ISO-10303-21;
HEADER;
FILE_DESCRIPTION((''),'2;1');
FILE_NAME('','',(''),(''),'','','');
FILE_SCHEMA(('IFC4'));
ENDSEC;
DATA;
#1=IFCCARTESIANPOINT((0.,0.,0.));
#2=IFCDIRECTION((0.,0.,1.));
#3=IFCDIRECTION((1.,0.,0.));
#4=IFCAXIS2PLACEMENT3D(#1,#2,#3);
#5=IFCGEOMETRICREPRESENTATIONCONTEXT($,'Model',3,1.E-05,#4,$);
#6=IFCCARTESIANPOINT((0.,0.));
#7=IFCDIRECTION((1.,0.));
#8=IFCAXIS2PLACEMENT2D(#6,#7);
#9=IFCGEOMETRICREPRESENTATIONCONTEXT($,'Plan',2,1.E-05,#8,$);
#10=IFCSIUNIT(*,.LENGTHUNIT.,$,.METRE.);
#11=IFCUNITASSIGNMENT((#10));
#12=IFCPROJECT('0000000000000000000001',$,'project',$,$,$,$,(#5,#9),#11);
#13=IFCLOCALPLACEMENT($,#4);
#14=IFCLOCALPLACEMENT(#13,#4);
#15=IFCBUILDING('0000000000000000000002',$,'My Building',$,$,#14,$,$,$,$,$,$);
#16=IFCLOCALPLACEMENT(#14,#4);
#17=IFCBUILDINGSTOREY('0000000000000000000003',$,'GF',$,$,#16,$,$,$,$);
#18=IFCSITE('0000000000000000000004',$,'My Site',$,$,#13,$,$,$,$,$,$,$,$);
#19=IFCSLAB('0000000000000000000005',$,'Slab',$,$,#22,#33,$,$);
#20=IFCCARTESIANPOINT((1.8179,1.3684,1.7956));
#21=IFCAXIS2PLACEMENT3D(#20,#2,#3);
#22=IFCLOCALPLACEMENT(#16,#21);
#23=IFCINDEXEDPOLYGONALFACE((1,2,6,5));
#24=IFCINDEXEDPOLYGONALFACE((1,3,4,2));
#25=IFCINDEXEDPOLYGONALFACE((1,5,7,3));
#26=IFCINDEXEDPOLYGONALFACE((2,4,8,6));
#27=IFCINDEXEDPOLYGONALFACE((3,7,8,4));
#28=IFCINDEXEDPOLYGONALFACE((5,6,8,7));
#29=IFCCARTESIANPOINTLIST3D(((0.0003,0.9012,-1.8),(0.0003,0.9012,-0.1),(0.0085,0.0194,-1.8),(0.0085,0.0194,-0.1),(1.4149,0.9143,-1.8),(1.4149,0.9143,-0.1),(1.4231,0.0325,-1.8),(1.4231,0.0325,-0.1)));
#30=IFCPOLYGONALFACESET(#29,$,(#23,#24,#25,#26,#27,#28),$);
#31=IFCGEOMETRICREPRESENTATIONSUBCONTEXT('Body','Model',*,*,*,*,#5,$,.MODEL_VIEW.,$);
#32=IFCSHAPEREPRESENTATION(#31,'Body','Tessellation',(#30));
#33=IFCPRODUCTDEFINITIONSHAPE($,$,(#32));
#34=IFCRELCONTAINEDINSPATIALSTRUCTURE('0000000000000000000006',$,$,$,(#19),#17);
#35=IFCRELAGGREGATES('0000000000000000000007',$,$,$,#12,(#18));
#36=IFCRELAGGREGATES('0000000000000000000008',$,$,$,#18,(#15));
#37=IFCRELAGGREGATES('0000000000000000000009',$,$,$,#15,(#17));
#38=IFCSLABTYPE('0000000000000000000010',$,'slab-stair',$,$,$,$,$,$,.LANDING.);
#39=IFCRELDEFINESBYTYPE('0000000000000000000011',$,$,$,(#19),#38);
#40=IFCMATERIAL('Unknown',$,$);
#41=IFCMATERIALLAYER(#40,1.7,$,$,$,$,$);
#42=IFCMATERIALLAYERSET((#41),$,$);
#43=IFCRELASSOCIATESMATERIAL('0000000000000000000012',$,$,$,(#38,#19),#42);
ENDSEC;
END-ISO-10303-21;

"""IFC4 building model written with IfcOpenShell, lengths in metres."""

from ifc_helpers import new_model, si_unit, frame, origin_with_axes, origin_2d_with_axis, place, context, subcontext, project, spatial, indexed_curve, outline, extrude, material, layer, layer_set, layer_usage, type_object, element, save


model = new_model("IFC4")

# Units and contexts
model_context = context("Model", 3, precision=1e-05, world=origin_with_axes())
plan_context = context("Plan", 2, precision=1e-05, world=origin_2d_with_axis())
body_context_1 = subcontext(model_context, "Body", "Model", "MODEL_VIEW")
ifc_project = project(units=[si_unit("LENGTHUNIT", "METRE")], contexts=[model_context, plan_context])

# Site, building, storey
site_placement = place(None, origin_with_axes())
site = spatial("IfcSite", under=ifc_project, at=site_placement, Name="My Site")
building_placement = place(site_placement, origin_with_axes())
building = spatial("IfcBuilding", under=site, at=building_placement, Name="My Building")
storey_placement = place(building_placement, origin_with_axes())
storey = spatial("IfcBuildingStorey", under=building, at=storey_placement, Name="GF")

# Shared definitions
ifc_material = material(Name="Unknown")

# Slab
ifc_layer_1 = layer(ifc_material, 1.7)
ifc_layer_set_1 = layer_set([ifc_layer_1])
ifc_layer_usage_1 = layer_usage(ifc_layer_set_1, "AXIS3", "POSITIVE", -1.8)
slab_type_1 = type_object("IfcSlabType", Name="slab-stair", PredefinedType="LANDING", material=ifc_layer_set_1)
slab_1_placement = place(storey_placement, frame((1.8179, 1.3684, 1.7956), z_axis=(0.0, 0.0, 1.0), x_axis=(1.0, 0.0, 0.0)))
element("IfcSlab", 1, at=slab_1_placement, inside=storey, type_object=slab_type_1, material=ifc_layer_usage_1, Name="Slab", context=body_context_1, shape_type="SweptSolid", body=[
    extrude(outline(indexed_curve([(0.0085, 0.0194), (0.0003, 0.9012), (1.4149, 0.9143), (1.4231, 0.0325), (0.0085, 0.0194)])), frame((0.0, 0.0, -1.8), z_axis=(0.0, 0.0, 1.0), x_axis=(1.0, 0.0, 0.0)), (0.0, 0.0, 1.0), 1.7),
])

save(model, "model.ifc")
